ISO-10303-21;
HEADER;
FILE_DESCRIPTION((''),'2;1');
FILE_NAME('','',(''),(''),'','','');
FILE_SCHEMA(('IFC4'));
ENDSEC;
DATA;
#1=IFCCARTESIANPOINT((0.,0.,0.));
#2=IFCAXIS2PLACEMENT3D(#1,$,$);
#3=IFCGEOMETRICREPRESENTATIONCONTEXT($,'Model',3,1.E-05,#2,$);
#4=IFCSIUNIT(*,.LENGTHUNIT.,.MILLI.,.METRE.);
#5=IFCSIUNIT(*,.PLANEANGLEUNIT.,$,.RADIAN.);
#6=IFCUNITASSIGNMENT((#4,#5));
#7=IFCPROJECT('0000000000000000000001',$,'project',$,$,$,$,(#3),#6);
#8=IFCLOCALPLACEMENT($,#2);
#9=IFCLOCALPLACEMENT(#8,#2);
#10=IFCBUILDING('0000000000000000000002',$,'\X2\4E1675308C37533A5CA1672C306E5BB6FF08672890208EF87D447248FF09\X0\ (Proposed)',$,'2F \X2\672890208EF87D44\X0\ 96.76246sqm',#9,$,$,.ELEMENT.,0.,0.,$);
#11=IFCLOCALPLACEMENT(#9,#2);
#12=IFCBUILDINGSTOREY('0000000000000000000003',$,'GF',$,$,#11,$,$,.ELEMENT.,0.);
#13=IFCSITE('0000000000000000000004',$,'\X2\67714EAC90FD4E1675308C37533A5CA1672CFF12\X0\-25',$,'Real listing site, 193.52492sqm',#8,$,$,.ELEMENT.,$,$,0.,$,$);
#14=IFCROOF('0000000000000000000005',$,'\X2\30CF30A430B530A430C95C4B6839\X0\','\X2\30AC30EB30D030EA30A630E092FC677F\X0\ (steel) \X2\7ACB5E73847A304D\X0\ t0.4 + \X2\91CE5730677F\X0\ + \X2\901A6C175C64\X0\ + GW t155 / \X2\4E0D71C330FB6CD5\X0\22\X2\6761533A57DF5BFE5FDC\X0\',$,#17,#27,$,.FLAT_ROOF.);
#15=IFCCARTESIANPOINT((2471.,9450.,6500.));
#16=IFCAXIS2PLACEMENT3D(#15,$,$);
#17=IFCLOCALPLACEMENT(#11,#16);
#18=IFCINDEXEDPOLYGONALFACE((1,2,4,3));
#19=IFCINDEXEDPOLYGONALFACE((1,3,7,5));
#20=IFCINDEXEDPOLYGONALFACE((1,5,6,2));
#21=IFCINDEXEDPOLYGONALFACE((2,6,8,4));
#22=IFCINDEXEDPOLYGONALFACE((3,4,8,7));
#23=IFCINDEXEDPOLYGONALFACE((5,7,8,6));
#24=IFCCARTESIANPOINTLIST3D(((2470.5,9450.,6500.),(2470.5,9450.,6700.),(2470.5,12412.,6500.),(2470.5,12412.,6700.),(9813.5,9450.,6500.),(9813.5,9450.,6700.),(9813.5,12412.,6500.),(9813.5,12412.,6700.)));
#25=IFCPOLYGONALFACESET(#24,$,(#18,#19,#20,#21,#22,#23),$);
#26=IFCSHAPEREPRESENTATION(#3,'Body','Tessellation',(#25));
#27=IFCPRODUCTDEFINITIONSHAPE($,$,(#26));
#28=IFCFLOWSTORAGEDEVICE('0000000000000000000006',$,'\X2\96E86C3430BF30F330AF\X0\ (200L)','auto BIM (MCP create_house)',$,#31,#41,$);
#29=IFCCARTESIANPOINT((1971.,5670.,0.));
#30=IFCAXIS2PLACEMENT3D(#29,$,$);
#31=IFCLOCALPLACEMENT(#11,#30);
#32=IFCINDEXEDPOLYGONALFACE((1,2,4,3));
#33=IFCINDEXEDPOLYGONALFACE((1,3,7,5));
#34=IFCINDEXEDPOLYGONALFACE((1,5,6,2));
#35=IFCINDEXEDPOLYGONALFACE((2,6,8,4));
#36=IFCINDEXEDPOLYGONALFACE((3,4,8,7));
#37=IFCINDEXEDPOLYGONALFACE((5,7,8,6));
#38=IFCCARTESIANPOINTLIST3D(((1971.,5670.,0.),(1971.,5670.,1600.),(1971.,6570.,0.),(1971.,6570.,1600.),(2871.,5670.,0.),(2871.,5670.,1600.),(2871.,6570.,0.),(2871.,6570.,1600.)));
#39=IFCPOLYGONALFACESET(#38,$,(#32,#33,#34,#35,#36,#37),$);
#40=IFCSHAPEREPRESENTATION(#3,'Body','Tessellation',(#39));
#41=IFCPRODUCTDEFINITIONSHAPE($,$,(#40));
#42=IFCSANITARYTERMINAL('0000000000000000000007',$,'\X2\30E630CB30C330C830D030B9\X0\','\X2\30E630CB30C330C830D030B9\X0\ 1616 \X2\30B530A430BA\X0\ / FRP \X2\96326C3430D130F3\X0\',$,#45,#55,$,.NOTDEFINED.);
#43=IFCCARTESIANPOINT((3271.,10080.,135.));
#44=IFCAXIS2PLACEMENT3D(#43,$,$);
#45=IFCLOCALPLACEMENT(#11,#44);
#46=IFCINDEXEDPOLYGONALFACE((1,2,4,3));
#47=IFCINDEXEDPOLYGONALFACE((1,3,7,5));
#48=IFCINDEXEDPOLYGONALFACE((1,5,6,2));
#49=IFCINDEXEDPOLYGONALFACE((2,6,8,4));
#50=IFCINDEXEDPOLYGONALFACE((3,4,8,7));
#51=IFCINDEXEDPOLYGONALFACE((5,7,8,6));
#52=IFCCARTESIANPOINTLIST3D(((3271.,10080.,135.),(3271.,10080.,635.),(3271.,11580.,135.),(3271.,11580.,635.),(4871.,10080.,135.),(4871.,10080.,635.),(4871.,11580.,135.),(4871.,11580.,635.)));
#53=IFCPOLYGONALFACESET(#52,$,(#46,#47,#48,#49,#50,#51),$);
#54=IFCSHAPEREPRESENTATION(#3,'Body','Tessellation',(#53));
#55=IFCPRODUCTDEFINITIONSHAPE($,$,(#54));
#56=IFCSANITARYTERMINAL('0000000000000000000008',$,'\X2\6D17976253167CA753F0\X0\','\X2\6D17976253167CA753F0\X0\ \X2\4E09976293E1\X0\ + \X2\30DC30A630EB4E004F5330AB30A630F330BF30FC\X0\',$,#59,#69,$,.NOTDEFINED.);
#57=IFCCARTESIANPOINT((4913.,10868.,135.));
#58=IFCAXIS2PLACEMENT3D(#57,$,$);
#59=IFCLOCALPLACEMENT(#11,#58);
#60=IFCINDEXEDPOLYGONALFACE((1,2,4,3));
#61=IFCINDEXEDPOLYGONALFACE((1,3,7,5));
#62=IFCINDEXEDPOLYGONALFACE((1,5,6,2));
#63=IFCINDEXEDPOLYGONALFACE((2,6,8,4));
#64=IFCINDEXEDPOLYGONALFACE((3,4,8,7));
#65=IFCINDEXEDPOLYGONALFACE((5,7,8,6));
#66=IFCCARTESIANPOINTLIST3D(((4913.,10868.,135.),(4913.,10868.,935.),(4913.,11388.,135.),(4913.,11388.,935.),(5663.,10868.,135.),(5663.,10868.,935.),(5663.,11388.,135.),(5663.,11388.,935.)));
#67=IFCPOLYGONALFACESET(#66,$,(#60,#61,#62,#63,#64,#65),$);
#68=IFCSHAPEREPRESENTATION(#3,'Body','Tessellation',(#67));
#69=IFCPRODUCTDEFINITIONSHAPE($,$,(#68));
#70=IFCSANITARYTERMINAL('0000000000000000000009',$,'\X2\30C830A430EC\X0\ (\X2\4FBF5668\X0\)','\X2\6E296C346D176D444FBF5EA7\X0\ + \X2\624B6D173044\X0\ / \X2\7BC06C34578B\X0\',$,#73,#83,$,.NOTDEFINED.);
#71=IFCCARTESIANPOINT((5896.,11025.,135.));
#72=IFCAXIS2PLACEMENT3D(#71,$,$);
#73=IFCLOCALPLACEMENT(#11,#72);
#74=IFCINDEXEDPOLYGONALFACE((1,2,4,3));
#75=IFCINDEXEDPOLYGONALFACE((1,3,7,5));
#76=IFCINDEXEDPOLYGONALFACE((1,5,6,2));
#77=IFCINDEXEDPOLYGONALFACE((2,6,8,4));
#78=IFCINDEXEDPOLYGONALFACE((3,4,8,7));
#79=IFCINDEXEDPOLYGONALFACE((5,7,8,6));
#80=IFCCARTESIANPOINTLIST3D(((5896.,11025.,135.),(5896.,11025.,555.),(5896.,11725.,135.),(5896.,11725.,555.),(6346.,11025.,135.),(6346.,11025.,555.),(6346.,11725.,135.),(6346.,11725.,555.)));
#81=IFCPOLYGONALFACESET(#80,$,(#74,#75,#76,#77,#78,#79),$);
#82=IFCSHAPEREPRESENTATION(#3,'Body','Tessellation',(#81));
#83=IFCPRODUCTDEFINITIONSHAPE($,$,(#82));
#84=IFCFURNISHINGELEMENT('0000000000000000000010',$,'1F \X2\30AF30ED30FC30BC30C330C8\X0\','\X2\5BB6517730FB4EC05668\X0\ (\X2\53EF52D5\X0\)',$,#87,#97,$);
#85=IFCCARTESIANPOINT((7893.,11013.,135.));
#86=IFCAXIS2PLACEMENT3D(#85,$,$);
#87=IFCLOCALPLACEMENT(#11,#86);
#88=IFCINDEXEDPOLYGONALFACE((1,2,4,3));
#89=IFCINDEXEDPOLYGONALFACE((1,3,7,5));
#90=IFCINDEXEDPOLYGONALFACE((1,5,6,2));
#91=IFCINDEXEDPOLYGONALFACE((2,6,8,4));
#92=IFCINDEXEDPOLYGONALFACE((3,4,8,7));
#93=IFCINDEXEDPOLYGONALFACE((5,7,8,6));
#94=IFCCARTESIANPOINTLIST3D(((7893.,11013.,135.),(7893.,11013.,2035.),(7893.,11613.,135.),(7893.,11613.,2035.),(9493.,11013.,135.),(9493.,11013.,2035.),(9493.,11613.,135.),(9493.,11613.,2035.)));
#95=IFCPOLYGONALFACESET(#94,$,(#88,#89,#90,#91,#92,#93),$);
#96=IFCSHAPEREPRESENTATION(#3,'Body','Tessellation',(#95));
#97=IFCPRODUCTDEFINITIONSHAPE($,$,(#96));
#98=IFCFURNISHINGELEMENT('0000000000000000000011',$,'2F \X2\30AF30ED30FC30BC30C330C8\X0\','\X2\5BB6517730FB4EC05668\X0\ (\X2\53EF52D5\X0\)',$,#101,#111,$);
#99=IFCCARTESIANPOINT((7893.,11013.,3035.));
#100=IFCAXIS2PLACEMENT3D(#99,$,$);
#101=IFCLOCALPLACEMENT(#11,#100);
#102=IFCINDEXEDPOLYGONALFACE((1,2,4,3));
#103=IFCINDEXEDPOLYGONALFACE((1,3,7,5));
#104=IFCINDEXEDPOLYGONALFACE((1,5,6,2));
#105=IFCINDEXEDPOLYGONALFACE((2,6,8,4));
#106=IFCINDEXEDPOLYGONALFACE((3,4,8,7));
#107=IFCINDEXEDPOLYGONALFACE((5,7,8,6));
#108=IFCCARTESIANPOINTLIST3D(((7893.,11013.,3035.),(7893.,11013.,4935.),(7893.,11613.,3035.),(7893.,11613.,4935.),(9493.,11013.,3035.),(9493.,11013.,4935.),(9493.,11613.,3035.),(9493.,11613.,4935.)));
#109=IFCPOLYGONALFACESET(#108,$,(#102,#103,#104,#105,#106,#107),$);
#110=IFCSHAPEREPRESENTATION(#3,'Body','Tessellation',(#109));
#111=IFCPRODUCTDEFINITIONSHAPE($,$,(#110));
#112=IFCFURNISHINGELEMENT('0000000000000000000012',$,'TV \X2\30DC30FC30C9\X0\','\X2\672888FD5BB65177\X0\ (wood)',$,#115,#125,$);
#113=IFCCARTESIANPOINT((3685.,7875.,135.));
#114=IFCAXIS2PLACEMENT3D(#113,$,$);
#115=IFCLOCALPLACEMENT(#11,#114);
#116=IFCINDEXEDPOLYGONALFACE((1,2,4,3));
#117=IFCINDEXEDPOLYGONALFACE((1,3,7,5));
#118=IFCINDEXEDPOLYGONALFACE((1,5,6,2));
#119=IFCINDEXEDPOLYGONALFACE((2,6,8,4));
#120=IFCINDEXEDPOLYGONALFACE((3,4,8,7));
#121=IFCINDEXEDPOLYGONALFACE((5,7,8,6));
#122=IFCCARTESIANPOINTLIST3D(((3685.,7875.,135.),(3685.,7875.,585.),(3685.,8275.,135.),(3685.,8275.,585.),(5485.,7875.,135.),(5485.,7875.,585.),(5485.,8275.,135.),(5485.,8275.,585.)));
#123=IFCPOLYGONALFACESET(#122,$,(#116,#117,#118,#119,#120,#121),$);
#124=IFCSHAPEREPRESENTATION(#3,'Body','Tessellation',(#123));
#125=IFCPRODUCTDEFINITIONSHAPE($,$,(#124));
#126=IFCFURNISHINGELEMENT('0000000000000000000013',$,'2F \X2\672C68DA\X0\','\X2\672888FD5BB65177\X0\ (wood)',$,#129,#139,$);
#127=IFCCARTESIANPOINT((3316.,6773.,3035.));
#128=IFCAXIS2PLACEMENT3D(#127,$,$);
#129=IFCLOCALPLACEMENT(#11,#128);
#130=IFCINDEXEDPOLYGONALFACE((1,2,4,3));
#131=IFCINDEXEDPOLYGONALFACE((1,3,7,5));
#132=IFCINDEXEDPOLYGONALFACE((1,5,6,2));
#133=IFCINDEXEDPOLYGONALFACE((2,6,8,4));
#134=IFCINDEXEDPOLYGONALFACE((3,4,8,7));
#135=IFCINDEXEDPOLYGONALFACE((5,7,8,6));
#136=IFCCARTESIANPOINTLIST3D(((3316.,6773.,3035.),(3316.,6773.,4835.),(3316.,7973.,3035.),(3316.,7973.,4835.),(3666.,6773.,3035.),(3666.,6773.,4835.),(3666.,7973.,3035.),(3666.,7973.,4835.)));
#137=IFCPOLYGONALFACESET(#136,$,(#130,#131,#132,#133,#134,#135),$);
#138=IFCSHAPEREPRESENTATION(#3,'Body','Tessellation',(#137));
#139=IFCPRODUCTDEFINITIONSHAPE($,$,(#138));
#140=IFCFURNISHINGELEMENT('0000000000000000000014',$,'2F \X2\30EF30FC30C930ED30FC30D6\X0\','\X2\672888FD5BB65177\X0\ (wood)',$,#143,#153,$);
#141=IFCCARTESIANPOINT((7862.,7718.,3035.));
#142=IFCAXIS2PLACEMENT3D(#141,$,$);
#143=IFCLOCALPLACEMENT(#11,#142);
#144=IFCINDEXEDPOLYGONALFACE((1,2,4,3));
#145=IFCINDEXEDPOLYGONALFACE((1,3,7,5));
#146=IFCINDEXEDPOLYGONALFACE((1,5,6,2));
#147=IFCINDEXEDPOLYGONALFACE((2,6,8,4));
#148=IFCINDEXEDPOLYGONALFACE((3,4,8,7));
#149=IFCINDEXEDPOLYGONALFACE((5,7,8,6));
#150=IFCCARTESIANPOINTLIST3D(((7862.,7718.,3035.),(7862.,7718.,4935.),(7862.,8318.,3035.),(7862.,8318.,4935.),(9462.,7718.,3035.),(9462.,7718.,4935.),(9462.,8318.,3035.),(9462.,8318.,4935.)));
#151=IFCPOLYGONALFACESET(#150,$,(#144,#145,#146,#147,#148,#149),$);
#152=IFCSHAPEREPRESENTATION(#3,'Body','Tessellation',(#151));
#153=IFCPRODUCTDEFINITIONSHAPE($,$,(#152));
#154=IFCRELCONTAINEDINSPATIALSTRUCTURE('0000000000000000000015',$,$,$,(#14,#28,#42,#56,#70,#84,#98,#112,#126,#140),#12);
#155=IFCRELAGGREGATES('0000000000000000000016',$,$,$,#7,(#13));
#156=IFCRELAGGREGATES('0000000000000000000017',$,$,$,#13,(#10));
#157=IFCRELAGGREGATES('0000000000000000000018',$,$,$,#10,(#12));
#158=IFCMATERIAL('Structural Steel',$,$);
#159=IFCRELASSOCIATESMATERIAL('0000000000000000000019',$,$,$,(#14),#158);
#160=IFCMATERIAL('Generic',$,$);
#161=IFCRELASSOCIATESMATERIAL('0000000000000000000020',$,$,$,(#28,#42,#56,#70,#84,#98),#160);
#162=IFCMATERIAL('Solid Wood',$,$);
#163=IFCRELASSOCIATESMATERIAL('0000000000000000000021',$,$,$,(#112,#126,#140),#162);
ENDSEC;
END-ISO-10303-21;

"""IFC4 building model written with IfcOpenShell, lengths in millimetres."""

from ifc_helpers import new_model, si_unit, frame, frame_2d, origin, place, context, project, spatial, rectangle, extrude, material, element, save


model = new_model("IFC4")

# Units and contexts
model_context = context("Model", 3, precision=1e-05, world=origin())
ifc_project = project(units=[si_unit("LENGTHUNIT", "METRE", prefix="MILLI"), si_unit("PLANEANGLEUNIT", "RADIAN")], contexts=[model_context])

# Site, building, storey
site_placement = place(None, origin())
site = spatial("IfcSite", under=ifc_project, at=site_placement, Name="東京都世田谷区岡本２-25", ObjectType="Real listing site, 193.52492sqm", CompositionType="ELEMENT", RefElevation=0.0)
building_placement = place(site_placement, origin())
building = spatial("IfcBuilding", under=site, at=building_placement, Name="世田谷区岡本の家（木造軸組版） (Proposed)", ObjectType="2F 木造軸組 96.76246sqm", CompositionType="ELEMENT", ElevationOfRefHeight=0.0, ElevationOfTerrain=0.0)
storey_placement = place(building_placement, origin())
storey = spatial("IfcBuildingStorey", under=building, at=storey_placement, Name="GF", CompositionType="ELEMENT", Elevation=0.0)

# Shared definitions
ifc_material_1 = material(Name="Solid Wood")

# Roof
ifc_material_2 = material(Name="Structural Steel")
roof_placement = place(storey_placement, frame((2471.0, 9450.0, 6500.0)))
element("IfcRoof", 1, at=roof_placement, inside=storey, material=ifc_material_2, Name="ハイサイド屋根", Description="ガルバリウム鋼板 (steel) 立平葺き t0.4 + 野地板 + 通気層 + GW t155 / 不燃・法22条区域対応", PredefinedType="FLAT_ROOF", context=model_context, shape_type="SweptSolid", body=[
    extrude(rectangle(XDim=7343.0, YDim=2962.0, at=frame_2d((3671.0, 1481.0))), frame((2471.0, 9450.0, 6500.0)), (0.0, 0.0, 1.0), 200.0),
])

# Flow storage device
ifc_material_3 = material(Name="Generic")
flow_storage_device_placement = place(storey_placement, frame((1971.0, 5670.0, 0.0)))
element("IfcFlowStorageDevice", 2, at=flow_storage_device_placement, inside=storey, material=ifc_material_3, Name="雨水タンク (200L)", Description="auto BIM (MCP create_house)", context=model_context, shape_type="SweptSolid", body=[
    extrude(rectangle(XDim=900.0, YDim=900.0, at=frame_2d((450.0, 450.0))), frame((1971.0, 5670.0, 0.0)), (0.0, 0.0, 1.0), 1600.0),
])

# Sanitary terminals
sanitary_terminal_1_placement = place(storey_placement, frame((3271.0, 10080.0, 135.0)))
element("IfcSanitaryTerminal", 3, at=sanitary_terminal_1_placement, inside=storey, material=ifc_material_3, Name="ユニットバス", Description="ユニットバス 1616 サイズ / FRP 防水パン", PredefinedType="NOTDEFINED", context=model_context, shape_type="SweptSolid", body=[
    extrude(rectangle(XDim=1600.0, YDim=1500.0, at=frame_2d((800.0, 750.0))), frame((3271.0, 10080.0, 135.0)), (0.0, 0.0, 1.0), 500.0),
])
sanitary_terminal_2_placement = place(storey_placement, frame((4913.0, 10868.0, 135.0)))
element("IfcSanitaryTerminal", 4, at=sanitary_terminal_2_placement, inside=storey, material=ifc_material_3, Name="洗面化粧台", Description="洗面化粧台 三面鏡 + ボウル一体カウンター", PredefinedType="NOTDEFINED", context=model_context, shape_type="SweptSolid", body=[
    extrude(rectangle(XDim=750.0, YDim=520.0, at=frame_2d((375.0, 260.0))), frame((4913.0, 10868.0, 135.0)), (0.0, 0.0, 1.0), 800.0),
])
sanitary_terminal_3_placement = place(storey_placement, frame((5896.0, 11025.0, 135.0)))
element("IfcSanitaryTerminal", 5, at=sanitary_terminal_3_placement, inside=storey, material=ifc_material_3, Name="トイレ (便器)", Description="温水洗浄便座 + 手洗い / 節水型", PredefinedType="NOTDEFINED", context=model_context, shape_type="SweptSolid", body=[
    extrude(rectangle(XDim=450.0, YDim=700.0, at=frame_2d((225.0, 350.0))), frame((5896.0, 11025.0, 135.0)), (0.0, 0.0, 1.0), 420.0),
])

# Furnishing elements
furnishing_1_placement = place(storey_placement, frame((7893.0, 11013.0, 135.0)))
element("IfcFurnishingElement", 6, at=furnishing_1_placement, inside=storey, material=ifc_material_3, Name="1F クローゼット", Description="家具・什器 (可動)", context=model_context, shape_type="SweptSolid", body=[
    extrude(rectangle(XDim=1600.0, YDim=600.0, at=frame_2d((800.0, 300.0))), frame((7893.0, 11013.0, 135.0)), (0.0, 0.0, 1.0), 1900.0),
])
furnishing_2_placement = place(storey_placement, frame((7893.0, 11013.0, 3035.0)))
element("IfcFurnishingElement", 7, at=furnishing_2_placement, inside=storey, material=ifc_material_3, Name="2F クローゼット", Description="家具・什器 (可動)", context=model_context, shape_type="SweptSolid", body=[
    extrude(rectangle(XDim=1600.0, YDim=600.0, at=frame_2d((800.0, 300.0))), frame((7893.0, 11013.0, 3035.0)), (0.0, 0.0, 1.0), 1900.0),
])
furnishing_3_placement = place(storey_placement, frame((3685.0, 7875.0, 135.0)))
element("IfcFurnishingElement", 8, at=furnishing_3_placement, inside=storey, material=ifc_material_1, Name="TV ボード", Description="木製家具 (wood)", context=model_context, shape_type="SweptSolid", body=[
    extrude(rectangle(XDim=1800.0, YDim=400.0, at=frame_2d((900.0, 200.0))), frame((3685.0, 7875.0, 135.0)), (0.0, 0.0, 1.0), 450.0),
])
furnishing_4_placement = place(storey_placement, frame((3316.0, 6773.0, 3035.0)))
element("IfcFurnishingElement", 9, at=furnishing_4_placement, inside=storey, material=ifc_material_1, Name="2F 本棚", Description="木製家具 (wood)", context=model_context, shape_type="SweptSolid", body=[
    extrude(rectangle(XDim=350.0, YDim=1200.0, at=frame_2d((175.0, 600.0))), frame((3316.0, 6773.0, 3035.0)), (0.0, 0.0, 1.0), 1800.0),
])
furnishing_5_placement = place(storey_placement, frame((7862.0, 7718.0, 3035.0)))
element("IfcFurnishingElement", 10, at=furnishing_5_placement, inside=storey, material=ifc_material_1, Name="2F ワードローブ", Description="木製家具 (wood)", context=model_context, shape_type="SweptSolid", body=[
    extrude(rectangle(XDim=1600.0, YDim=600.0, at=frame_2d((800.0, 300.0))), frame((7862.0, 7718.0, 3035.0)), (0.0, 0.0, 1.0), 1900.0),
])

save(model, "model.ifc")
